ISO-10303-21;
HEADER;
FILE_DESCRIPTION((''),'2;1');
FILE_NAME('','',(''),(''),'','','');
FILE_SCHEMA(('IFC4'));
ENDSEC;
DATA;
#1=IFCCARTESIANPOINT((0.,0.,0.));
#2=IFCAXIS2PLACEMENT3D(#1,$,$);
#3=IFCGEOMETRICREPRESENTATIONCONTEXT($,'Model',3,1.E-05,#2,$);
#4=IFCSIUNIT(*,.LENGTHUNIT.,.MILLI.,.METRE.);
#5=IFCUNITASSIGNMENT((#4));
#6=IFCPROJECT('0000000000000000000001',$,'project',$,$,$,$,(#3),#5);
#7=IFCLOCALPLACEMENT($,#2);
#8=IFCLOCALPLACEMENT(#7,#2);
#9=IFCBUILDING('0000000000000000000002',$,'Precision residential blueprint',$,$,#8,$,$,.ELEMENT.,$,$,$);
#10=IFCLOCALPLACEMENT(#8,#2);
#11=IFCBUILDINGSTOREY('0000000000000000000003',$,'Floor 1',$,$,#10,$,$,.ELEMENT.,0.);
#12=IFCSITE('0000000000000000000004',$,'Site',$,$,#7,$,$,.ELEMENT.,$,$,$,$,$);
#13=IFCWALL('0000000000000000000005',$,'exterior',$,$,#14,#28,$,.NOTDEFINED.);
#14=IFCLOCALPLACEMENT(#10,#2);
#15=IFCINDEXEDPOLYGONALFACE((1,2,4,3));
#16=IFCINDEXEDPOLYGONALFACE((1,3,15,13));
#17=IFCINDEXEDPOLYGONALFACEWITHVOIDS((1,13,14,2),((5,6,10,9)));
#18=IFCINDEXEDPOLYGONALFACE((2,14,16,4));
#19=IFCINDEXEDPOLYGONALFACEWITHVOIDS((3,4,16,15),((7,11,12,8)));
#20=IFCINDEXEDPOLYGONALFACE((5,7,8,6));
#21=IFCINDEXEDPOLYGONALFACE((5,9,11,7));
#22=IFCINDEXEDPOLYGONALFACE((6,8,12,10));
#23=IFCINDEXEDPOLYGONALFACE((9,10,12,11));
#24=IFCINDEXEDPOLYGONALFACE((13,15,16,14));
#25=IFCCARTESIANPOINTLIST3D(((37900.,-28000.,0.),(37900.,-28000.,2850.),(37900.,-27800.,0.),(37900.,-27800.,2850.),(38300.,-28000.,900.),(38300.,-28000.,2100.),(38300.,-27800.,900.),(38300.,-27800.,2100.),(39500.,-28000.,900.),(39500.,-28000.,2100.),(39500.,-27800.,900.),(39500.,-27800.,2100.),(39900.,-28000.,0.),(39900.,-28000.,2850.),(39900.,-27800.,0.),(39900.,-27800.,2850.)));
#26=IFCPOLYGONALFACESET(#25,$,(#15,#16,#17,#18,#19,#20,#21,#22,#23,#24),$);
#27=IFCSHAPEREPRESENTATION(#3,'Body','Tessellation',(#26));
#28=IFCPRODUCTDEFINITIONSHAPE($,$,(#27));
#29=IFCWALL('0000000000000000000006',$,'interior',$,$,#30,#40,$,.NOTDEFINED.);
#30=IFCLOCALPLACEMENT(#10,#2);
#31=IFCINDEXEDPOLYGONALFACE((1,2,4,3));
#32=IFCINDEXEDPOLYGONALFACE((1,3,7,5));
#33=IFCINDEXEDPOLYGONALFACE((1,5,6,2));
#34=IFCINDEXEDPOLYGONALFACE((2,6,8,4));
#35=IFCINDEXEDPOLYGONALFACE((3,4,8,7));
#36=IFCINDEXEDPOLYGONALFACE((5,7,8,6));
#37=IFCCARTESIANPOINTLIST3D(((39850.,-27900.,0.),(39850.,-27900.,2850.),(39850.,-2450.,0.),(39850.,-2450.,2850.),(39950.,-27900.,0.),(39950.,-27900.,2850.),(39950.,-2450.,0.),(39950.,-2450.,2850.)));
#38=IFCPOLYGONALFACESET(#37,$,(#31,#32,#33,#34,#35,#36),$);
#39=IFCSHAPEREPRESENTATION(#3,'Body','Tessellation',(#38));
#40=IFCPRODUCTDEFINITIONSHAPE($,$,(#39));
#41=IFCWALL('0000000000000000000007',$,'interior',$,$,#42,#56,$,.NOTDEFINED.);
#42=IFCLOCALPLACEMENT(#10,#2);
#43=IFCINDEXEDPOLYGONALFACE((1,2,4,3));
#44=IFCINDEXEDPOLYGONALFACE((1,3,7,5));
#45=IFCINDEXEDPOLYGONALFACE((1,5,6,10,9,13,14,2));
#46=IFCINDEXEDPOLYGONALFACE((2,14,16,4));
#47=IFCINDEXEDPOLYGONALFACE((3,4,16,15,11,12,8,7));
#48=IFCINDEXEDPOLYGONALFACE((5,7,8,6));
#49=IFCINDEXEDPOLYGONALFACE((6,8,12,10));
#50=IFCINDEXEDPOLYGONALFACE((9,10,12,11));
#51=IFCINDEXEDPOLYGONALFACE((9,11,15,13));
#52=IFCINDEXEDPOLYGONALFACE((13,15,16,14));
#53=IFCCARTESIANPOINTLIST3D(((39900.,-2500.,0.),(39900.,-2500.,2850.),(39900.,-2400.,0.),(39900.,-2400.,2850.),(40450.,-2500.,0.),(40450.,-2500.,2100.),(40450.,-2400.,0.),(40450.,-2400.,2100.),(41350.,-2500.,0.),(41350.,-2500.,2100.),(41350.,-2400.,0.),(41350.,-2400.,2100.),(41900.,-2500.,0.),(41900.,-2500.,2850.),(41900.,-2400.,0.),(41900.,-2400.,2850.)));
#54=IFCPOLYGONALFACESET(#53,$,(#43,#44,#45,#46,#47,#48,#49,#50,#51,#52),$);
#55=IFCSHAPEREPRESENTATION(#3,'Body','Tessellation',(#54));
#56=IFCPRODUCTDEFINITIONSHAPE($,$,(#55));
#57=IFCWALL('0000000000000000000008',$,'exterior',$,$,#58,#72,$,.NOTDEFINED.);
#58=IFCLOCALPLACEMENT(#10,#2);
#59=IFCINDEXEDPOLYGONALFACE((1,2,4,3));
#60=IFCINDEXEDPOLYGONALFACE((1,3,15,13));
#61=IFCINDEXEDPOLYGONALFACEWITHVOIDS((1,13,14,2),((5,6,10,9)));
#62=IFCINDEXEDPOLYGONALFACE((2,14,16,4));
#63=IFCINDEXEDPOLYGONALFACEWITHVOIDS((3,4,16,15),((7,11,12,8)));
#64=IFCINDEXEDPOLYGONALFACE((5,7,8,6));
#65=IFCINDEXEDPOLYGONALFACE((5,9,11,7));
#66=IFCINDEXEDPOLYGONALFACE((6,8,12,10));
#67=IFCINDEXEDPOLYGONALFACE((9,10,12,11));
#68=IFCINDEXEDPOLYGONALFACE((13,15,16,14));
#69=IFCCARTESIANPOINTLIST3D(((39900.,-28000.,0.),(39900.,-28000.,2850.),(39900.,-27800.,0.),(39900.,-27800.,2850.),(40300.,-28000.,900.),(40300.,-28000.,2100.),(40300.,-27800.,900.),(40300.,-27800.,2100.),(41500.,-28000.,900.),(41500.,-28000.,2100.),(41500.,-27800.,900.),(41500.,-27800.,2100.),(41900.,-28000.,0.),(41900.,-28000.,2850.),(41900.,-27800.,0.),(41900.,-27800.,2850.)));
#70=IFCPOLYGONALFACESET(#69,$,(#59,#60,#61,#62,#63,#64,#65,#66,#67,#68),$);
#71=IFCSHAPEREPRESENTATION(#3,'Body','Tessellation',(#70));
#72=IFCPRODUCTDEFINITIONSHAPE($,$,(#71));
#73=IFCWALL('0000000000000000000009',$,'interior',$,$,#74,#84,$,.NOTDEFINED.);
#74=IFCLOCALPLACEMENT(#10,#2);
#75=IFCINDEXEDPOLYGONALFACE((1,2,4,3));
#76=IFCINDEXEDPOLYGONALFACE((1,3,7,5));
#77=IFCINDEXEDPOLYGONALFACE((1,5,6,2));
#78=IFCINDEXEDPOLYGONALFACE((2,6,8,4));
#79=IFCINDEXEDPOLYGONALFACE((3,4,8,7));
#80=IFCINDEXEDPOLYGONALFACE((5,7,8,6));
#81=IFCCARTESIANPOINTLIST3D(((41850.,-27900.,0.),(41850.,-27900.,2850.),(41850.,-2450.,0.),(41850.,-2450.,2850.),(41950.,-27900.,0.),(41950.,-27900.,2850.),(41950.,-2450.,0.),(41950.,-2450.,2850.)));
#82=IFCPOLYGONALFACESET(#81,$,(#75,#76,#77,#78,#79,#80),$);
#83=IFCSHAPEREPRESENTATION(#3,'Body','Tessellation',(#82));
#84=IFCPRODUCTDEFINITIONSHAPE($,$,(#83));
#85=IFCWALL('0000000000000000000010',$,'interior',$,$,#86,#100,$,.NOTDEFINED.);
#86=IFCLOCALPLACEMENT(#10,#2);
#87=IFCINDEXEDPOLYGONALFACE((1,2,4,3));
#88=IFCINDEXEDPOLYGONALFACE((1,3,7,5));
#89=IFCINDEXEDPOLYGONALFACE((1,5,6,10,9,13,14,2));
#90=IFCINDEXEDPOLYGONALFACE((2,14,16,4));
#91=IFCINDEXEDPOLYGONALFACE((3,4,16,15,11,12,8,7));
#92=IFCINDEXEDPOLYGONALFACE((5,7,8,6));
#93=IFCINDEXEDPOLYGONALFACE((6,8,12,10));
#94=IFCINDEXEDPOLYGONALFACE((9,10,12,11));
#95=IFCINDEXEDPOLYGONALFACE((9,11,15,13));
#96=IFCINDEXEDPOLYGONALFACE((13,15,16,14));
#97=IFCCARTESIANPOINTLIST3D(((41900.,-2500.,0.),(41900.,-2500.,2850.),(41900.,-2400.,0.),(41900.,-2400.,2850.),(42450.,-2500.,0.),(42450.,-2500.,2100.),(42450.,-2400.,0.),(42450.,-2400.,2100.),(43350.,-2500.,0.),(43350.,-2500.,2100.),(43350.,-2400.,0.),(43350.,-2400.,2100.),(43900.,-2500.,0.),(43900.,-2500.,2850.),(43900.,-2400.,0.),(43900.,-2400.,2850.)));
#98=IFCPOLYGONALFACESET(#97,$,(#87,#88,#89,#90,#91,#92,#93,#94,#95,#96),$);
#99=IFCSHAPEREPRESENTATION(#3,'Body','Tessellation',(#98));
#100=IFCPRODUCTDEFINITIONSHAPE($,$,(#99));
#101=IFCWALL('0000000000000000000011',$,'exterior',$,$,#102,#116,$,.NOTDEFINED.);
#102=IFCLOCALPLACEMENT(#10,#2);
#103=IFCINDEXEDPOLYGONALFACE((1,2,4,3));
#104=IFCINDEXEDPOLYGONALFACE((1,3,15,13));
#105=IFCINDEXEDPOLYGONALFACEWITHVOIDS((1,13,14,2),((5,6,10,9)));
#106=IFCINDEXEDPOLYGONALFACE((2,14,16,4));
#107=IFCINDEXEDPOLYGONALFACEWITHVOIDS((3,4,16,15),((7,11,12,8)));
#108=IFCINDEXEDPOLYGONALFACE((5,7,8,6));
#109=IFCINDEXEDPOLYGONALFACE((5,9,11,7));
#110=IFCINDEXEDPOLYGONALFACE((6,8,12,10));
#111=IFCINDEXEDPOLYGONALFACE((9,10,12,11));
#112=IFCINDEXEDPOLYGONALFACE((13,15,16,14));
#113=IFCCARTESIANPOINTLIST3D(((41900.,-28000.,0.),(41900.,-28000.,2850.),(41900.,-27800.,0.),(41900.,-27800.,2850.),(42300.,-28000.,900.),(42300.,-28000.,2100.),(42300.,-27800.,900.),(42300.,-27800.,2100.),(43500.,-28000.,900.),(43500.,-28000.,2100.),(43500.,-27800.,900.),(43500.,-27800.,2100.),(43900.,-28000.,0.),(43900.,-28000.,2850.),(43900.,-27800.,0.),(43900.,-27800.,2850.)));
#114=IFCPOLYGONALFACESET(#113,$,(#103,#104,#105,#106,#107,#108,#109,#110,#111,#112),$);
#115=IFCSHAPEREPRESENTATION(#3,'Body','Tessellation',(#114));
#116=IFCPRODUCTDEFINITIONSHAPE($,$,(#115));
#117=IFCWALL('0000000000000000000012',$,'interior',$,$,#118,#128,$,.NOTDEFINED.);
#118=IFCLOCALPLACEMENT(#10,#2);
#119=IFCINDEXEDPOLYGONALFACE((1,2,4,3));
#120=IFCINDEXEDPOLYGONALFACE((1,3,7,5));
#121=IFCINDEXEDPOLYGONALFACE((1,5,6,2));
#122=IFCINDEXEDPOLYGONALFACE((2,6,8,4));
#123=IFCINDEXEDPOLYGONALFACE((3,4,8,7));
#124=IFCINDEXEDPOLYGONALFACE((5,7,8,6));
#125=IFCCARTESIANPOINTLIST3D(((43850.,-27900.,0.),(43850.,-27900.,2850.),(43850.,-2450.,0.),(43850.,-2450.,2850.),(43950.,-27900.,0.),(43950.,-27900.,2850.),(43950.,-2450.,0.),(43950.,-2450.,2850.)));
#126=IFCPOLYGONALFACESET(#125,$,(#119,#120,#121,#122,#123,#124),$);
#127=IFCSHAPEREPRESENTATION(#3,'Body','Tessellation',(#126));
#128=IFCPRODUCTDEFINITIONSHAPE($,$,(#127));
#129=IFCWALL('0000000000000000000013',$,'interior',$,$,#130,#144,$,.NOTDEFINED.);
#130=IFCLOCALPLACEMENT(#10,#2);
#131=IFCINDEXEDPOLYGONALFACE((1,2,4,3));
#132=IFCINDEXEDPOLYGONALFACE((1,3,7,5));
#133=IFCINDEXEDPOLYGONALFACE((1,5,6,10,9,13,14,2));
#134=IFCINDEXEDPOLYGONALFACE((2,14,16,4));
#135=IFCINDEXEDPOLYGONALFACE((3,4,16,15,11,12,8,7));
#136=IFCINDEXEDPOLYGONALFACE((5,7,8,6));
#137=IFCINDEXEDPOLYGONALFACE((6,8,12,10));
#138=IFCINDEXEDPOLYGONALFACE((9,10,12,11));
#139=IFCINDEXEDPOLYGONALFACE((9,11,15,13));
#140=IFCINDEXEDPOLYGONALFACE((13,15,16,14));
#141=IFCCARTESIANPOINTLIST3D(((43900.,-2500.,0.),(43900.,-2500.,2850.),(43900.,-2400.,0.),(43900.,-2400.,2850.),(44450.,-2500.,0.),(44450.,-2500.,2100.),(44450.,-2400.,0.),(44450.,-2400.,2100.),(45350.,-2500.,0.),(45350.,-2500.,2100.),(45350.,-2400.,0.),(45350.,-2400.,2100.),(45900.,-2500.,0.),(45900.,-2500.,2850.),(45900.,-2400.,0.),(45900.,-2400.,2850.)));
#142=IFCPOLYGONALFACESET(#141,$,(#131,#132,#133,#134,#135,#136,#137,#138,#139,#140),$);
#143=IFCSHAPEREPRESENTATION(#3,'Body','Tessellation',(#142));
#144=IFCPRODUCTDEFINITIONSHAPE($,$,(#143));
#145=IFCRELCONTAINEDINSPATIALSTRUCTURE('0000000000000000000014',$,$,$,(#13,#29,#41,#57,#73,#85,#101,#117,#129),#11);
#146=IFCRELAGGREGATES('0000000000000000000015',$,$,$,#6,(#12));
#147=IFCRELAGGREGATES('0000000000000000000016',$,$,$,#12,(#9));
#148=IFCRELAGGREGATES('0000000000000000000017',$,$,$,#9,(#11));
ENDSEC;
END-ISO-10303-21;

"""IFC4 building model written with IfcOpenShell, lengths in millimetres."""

from ifc_helpers import new_model, si_unit, frame, origin, place, context, project, spatial, polyline, outline, extrude, element, save


model = new_model("IFC4")

# Units and contexts
model_context = context("Model", 3, precision=1e-05, world=origin())
ifc_project = project(units=[si_unit("LENGTHUNIT", "METRE", prefix="MILLI")], contexts=[model_context])

# Site, building, storey
site_placement = place(None, origin())
site = spatial("IfcSite", under=ifc_project, at=site_placement, Name="Site", CompositionType="ELEMENT")
building_placement = place(site_placement, origin())
building = spatial("IfcBuilding", under=site, at=building_placement, Name="Precision residential blueprint", CompositionType="ELEMENT")
storey_placement = place(building_placement, origin())
storey = spatial("IfcBuildingStorey", under=building, at=storey_placement, Name="Floor 1", CompositionType="ELEMENT", Elevation=0.0)

# Wall, opening
wall_1_placement = place(storey_placement, origin())
wall_1 = element("IfcWall", 1, at=wall_1_placement, inside=storey, Name="exterior", PredefinedType="NOTDEFINED", context=model_context, shape_type="SweptSolid", body=[
    extrude(outline(polyline([(37900.0, -27800.0), (39900.0, -27800.0), (39900.0, -28000.0), (37900.0, -28000.0), (37900.0, -27800.0)])), origin(), (0.0, 0.0, 1.0), 2850.0),
])
opening_1_placement = place(storey_placement, origin())
element("IfcOpeningElement", 2, at=opening_1_placement, cuts=wall_1, PredefinedType="OPENING", context=model_context, shape_type="SweptSolid", body=[
    extrude(outline(polyline([(38300.0, -27800.0), (39500.0, -27800.0), (39500.0, -28000.0), (38300.0, -28000.0), (38300.0, -27800.0)])), frame((0.0, 0.0, 900.0)), (0.0, 0.0, 1.0), 1200.0),
])

# Wall
wall_2_placement = place(storey_placement, origin())
element("IfcWall", 3, at=wall_2_placement, inside=storey, Name="interior", PredefinedType="NOTDEFINED", context=model_context, shape_type="SweptSolid", body=[
    extrude(outline(polyline([(39950.0, -2450.0), (39950.0, -27900.0), (39850.0, -27900.0), (39850.0, -2450.0), (39950.0, -2450.0)])), origin(), (0.0, 0.0, 1.0), 2850.0),
])

# Walls, openings
wall_3_placement = place(storey_placement, origin())
wall_3 = element("IfcWall", 4, at=wall_3_placement, inside=storey, Name="interior", PredefinedType="NOTDEFINED", context=model_context, shape_type="SweptSolid", body=[
    extrude(outline(polyline([(39900.0, -2400.0), (41900.0, -2400.0), (41900.0, -2500.0), (39900.0, -2500.0), (39900.0, -2400.0)])), origin(), (0.0, 0.0, 1.0), 2850.0),
])
opening_2_placement = place(storey_placement, origin())
element("IfcOpeningElement", 5, at=opening_2_placement, cuts=wall_3, PredefinedType="OPENING", context=model_context, shape_type="SweptSolid", body=[
    extrude(outline(polyline([(40450.0, -2400.0), (41350.0, -2400.0), (41350.0, -2500.0), (40450.0, -2500.0), (40450.0, -2400.0)])), origin(), (0.0, 0.0, 1.0), 2100.0),
])
wall_4_placement = place(storey_placement, origin())
wall_4 = element("IfcWall", 6, at=wall_4_placement, inside=storey, Name="exterior", PredefinedType="NOTDEFINED", context=model_context, shape_type="SweptSolid", body=[
    extrude(outline(polyline([(39900.0, -27800.0), (41900.0, -27800.0), (41900.0, -28000.0), (39900.0, -28000.0), (39900.0, -27800.0)])), origin(), (0.0, 0.0, 1.0), 2850.0),
])
opening_3_placement = place(storey_placement, origin())
element("IfcOpeningElement", 7, at=opening_3_placement, cuts=wall_4, PredefinedType="OPENING", context=model_context, shape_type="SweptSolid", body=[
    extrude(outline(polyline([(40300.0, -27800.0), (41500.0, -27800.0), (41500.0, -28000.0), (40300.0, -28000.0), (40300.0, -27800.0)])), frame((0.0, 0.0, 900.0)), (0.0, 0.0, 1.0), 1200.0),
])

# Wall
wall_5_placement = place(storey_placement, origin())
element("IfcWall", 8, at=wall_5_placement, inside=storey, Name="interior", PredefinedType="NOTDEFINED", context=model_context, shape_type="SweptSolid", body=[
    extrude(outline(polyline([(41950.0, -2450.0), (41950.0, -27900.0), (41850.0, -27900.0), (41850.0, -2450.0), (41950.0, -2450.0)])), origin(), (0.0, 0.0, 1.0), 2850.0),
])

# Walls, openings
wall_6_placement = place(storey_placement, origin())
wall_6 = element("IfcWall", 9, at=wall_6_placement, inside=storey, Name="interior", PredefinedType="NOTDEFINED", context=model_context, shape_type="SweptSolid", body=[
    extrude(outline(polyline([(41900.0, -2400.0), (43900.0, -2400.0), (43900.0, -2500.0), (41900.0, -2500.0), (41900.0, -2400.0)])), origin(), (0.0, 0.0, 1.0), 2850.0),
])
opening_4_placement = place(storey_placement, origin())
element("IfcOpeningElement", 10, at=opening_4_placement, cuts=wall_6, PredefinedType="OPENING", context=model_context, shape_type="SweptSolid", body=[
    extrude(outline(polyline([(42450.0, -2400.0), (43350.0, -2400.0), (43350.0, -2500.0), (42450.0, -2500.0), (42450.0, -2400.0)])), origin(), (0.0, 0.0, 1.0), 2100.0),
])
wall_7_placement = place(storey_placement, origin())
wall_7 = element("IfcWall", 11, at=wall_7_placement, inside=storey, Name="exterior", PredefinedType="NOTDEFINED", context=model_context, shape_type="SweptSolid", body=[
    extrude(outline(polyline([(41900.0, -27800.0), (43900.0, -27800.0), (43900.0, -28000.0), (41900.0, -28000.0), (41900.0, -27800.0)])), origin(), (0.0, 0.0, 1.0), 2850.0),
])
opening_5_placement = place(storey_placement, origin())
element("IfcOpeningElement", 12, at=opening_5_placement, cuts=wall_7, PredefinedType="OPENING", context=model_context, shape_type="SweptSolid", body=[
    extrude(outline(polyline([(42300.0, -27800.0), (43500.0, -27800.0), (43500.0, -28000.0), (42300.0, -28000.0), (42300.0, -27800.0)])), frame((0.0, 0.0, 900.0)), (0.0, 0.0, 1.0), 1200.0),
])

# Wall
wall_8_placement = place(storey_placement, origin())
element("IfcWall", 13, at=wall_8_placement, inside=storey, Name="interior", PredefinedType="NOTDEFINED", context=model_context, shape_type="SweptSolid", body=[
    extrude(outline(polyline([(43950.0, -2450.0), (43950.0, -27900.0), (43850.0, -27900.0), (43850.0, -2450.0), (43950.0, -2450.0)])), origin(), (0.0, 0.0, 1.0), 2850.0),
])

# Wall, opening
wall_9_placement = place(storey_placement, origin())
wall_9 = element("IfcWall", 14, at=wall_9_placement, inside=storey, Name="interior", PredefinedType="NOTDEFINED", context=model_context, shape_type="SweptSolid", body=[
    extrude(outline(polyline([(43900.0, -2400.0), (45900.0, -2400.0), (45900.0, -2500.0), (43900.0, -2500.0), (43900.0, -2400.0)])), origin(), (0.0, 0.0, 1.0), 2850.0),
])
opening_6_placement = place(storey_placement, origin())
element("IfcOpeningElement", 15, at=opening_6_placement, cuts=wall_9, PredefinedType="OPENING", context=model_context, shape_type="SweptSolid", body=[
    extrude(outline(polyline([(44450.0, -2400.0), (45350.0, -2400.0), (45350.0, -2500.0), (44450.0, -2500.0), (44450.0, -2400.0)])), origin(), (0.0, 0.0, 1.0), 2100.0),
])

save(model, "model.ifc")
